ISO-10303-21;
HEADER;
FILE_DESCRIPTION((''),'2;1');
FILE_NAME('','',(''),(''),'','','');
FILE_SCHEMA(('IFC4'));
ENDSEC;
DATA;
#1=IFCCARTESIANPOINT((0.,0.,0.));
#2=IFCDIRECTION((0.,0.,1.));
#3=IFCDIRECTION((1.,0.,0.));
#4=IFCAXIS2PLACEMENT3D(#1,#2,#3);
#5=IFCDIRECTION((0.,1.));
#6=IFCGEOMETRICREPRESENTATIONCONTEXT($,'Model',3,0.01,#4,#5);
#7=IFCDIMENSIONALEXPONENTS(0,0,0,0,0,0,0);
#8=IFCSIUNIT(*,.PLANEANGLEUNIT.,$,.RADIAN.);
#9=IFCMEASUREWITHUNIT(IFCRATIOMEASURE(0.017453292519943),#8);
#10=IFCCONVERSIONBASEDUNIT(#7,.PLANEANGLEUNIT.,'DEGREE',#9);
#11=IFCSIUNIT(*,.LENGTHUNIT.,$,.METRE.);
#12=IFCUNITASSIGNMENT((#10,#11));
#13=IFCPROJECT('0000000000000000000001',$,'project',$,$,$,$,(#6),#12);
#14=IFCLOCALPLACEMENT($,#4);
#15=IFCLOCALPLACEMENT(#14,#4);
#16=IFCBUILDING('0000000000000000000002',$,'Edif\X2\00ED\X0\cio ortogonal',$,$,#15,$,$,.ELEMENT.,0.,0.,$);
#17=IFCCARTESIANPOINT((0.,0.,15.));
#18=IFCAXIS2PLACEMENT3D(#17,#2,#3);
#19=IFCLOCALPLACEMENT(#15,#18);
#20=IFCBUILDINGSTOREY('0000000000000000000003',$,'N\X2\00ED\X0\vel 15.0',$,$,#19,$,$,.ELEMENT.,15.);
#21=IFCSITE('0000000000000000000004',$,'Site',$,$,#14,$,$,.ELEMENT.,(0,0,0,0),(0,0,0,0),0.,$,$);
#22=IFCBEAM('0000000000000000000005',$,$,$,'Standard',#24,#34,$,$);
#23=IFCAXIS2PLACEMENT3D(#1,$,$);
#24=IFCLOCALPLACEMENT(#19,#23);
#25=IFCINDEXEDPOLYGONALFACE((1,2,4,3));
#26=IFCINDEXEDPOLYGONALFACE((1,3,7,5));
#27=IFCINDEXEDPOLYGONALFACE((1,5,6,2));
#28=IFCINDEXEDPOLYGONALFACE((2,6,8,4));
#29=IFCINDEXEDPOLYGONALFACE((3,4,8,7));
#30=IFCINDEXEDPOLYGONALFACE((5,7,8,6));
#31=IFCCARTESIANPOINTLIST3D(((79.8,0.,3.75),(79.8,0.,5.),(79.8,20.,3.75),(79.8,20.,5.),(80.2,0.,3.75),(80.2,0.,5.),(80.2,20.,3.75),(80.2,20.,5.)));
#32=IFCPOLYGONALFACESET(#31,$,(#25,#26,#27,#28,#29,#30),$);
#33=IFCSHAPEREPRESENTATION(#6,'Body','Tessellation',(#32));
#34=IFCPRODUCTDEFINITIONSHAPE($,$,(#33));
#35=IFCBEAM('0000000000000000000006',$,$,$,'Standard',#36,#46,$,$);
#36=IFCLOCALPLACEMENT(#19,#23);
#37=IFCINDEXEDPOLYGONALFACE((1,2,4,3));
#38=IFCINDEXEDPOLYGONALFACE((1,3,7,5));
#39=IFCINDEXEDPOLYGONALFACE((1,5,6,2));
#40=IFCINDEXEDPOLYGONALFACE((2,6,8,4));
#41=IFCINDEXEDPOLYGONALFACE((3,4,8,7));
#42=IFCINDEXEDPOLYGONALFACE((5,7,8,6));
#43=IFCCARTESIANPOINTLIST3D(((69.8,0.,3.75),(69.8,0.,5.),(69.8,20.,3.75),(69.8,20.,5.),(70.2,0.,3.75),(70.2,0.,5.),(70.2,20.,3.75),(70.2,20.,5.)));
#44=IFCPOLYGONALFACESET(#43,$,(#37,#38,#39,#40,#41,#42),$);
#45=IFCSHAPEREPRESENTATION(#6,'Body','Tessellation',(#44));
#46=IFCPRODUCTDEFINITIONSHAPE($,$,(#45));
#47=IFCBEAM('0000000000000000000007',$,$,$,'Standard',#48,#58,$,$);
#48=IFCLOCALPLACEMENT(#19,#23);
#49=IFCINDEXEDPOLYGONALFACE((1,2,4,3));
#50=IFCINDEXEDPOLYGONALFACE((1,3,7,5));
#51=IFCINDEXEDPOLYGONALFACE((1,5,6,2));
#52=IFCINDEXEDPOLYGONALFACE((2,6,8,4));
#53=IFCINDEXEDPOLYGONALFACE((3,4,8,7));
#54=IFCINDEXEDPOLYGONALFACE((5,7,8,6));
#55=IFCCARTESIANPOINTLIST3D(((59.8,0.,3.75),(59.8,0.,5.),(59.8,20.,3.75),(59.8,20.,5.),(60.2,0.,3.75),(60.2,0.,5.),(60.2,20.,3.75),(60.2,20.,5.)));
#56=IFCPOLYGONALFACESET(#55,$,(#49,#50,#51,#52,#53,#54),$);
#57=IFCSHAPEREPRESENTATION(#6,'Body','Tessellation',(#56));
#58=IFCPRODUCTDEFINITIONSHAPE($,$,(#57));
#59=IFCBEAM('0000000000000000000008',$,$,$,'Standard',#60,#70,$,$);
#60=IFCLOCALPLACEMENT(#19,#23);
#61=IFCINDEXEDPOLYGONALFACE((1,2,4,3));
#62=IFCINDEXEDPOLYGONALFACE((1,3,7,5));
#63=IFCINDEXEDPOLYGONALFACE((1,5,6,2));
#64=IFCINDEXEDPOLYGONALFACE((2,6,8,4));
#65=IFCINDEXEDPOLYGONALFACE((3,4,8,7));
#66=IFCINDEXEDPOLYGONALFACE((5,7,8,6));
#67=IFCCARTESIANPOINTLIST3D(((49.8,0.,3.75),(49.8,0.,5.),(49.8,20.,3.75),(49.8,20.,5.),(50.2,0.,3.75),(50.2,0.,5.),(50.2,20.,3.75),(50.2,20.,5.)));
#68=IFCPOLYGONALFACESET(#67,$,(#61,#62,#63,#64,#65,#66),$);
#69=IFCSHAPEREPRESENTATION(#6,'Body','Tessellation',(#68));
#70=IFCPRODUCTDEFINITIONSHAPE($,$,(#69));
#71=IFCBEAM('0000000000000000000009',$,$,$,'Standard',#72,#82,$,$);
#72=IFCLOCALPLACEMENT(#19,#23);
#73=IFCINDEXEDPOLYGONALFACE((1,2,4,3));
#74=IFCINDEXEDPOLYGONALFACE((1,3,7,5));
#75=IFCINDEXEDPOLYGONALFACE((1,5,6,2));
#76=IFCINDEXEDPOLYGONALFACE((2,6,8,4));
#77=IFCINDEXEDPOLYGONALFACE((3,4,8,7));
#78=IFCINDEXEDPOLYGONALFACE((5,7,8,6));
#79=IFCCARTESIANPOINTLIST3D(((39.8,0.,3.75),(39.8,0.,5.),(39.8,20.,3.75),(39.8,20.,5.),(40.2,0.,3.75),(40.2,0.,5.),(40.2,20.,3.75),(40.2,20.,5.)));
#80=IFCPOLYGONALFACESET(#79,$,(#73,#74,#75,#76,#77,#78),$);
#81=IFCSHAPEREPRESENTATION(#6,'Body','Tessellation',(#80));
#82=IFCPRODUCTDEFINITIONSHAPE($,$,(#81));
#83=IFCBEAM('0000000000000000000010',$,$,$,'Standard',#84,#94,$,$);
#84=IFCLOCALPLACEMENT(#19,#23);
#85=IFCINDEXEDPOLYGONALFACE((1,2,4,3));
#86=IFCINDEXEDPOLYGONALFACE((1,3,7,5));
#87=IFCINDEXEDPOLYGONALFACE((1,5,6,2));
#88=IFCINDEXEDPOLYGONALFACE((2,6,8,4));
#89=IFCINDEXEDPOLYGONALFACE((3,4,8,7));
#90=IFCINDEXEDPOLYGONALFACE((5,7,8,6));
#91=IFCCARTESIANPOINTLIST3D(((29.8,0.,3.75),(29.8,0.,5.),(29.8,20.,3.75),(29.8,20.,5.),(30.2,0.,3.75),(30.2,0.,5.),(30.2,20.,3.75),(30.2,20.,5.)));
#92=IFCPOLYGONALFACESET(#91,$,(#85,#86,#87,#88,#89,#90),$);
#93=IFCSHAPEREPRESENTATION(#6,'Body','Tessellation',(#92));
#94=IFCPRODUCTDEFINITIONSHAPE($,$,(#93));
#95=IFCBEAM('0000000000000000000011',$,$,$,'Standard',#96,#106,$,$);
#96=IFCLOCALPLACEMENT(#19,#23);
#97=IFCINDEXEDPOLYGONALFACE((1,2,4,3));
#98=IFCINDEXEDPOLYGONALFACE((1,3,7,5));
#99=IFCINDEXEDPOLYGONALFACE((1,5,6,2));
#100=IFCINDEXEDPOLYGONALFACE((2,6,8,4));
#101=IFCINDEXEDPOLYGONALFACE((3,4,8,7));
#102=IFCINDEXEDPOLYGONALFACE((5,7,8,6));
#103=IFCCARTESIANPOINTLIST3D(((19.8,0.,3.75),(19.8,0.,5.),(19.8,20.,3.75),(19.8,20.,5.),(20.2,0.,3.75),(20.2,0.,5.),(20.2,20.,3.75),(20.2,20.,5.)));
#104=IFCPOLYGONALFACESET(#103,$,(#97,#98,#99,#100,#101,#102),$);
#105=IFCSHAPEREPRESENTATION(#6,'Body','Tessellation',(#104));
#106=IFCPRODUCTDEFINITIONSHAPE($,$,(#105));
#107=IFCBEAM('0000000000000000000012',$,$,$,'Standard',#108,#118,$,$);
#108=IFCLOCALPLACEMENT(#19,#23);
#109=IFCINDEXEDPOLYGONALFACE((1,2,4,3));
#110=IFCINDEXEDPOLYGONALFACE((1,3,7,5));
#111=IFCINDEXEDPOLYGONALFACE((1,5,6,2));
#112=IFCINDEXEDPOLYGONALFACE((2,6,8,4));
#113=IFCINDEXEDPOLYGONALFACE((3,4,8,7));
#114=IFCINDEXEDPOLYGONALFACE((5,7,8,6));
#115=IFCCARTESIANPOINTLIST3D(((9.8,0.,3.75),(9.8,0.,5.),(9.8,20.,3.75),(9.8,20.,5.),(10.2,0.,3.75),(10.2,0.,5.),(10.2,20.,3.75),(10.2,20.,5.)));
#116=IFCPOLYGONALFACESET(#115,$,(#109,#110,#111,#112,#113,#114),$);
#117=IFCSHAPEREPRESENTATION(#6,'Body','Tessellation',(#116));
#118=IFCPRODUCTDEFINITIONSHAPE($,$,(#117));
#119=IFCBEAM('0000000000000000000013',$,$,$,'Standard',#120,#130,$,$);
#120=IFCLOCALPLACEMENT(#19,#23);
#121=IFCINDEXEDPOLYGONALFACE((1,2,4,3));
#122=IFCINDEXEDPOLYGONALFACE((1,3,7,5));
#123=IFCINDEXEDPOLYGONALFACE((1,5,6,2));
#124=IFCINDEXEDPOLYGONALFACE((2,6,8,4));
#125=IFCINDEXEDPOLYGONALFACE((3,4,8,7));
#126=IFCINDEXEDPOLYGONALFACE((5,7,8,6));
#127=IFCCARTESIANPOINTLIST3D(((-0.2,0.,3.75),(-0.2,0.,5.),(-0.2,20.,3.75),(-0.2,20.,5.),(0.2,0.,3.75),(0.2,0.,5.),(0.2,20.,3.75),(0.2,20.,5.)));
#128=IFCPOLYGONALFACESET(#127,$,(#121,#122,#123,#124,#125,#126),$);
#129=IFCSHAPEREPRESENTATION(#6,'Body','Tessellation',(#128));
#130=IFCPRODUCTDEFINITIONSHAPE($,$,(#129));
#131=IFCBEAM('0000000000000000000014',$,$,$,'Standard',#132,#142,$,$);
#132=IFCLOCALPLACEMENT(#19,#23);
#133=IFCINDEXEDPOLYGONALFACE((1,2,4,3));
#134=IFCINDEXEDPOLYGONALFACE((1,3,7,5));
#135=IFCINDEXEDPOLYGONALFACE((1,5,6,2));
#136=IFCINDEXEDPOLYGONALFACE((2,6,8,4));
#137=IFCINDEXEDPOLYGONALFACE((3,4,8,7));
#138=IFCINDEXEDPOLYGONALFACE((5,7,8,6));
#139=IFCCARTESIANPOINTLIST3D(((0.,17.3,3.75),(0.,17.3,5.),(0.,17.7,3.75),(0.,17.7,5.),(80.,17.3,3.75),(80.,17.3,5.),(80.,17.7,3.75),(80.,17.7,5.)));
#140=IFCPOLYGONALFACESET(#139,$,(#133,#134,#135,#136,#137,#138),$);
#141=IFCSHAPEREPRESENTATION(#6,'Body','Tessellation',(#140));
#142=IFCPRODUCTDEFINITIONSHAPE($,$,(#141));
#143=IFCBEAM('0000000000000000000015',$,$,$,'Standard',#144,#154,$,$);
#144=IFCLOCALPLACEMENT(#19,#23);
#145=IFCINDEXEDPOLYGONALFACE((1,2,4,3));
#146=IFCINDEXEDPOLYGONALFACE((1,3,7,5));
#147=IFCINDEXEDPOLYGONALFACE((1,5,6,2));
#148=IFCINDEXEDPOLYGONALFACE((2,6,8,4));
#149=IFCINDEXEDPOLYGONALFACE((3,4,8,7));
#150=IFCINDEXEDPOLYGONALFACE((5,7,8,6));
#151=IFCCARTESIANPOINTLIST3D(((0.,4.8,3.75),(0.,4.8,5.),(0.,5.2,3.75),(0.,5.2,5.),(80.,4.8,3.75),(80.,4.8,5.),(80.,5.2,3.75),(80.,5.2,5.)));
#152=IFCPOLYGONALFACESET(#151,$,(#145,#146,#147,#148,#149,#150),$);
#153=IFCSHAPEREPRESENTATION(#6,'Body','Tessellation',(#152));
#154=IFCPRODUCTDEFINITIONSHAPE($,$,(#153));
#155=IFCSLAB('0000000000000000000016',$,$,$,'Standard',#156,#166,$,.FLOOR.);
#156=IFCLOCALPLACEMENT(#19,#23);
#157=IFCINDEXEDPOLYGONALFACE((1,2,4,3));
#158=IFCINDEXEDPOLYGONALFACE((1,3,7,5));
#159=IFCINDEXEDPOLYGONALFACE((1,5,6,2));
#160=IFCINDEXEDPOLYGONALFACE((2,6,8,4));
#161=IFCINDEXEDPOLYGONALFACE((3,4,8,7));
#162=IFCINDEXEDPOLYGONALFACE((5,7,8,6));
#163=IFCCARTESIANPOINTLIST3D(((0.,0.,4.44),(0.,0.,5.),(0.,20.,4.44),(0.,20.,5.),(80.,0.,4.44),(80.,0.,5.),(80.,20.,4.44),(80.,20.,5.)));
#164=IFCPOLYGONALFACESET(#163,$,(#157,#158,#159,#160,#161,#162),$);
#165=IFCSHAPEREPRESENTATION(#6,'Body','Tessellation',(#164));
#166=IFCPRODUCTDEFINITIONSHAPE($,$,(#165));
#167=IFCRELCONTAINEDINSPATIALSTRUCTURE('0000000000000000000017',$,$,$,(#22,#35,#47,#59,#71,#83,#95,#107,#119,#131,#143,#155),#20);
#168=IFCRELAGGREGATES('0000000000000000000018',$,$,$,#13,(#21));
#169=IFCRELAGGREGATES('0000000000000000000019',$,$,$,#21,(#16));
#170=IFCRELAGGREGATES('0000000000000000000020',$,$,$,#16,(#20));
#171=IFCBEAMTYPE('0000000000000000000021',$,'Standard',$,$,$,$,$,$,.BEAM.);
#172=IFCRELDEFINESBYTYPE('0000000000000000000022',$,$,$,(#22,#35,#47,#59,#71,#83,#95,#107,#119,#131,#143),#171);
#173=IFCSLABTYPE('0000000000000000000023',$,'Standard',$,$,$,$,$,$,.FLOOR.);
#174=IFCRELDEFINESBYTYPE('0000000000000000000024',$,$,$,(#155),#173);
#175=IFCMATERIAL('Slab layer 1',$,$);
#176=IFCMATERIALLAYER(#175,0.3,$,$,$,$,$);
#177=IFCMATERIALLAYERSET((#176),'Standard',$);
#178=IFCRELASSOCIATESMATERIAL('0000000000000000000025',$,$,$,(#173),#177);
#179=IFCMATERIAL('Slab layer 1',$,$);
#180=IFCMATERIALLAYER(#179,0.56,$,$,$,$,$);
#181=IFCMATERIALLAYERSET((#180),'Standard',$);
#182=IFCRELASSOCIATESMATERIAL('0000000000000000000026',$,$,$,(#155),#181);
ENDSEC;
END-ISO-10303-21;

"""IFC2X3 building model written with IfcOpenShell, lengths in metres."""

from ifc_helpers import new_model, entity, si_unit, converted_unit, direction, frame, origin_with_axes, origin_2d, place, context, project, spatial, polyline, rectangle, outline, extrude, material, layer, layer_set, layer_usage, type_object, element, save


model = new_model("IFC2X3")

# Units and contexts
model_context = context("Model", 3, precision=0.01, world=origin_with_axes(), true_north=direction((0.0, 1.0)))
ifc_project = project(units=[converted_unit("PLANEANGLEUNIT", "DEGREE", entity("IfcRatioMeasure", 0.017453292519943), si_unit("PLANEANGLEUNIT", "RADIAN"), dimensions=[0, 0, 0, 0, 0, 0, 0]), si_unit("LENGTHUNIT", "METRE")], contexts=[model_context])

# Site, building, storey
site_placement = place(None, origin_with_axes())
site = spatial("IfcSite", under=ifc_project, at=site_placement, Name="Site", CompositionType="ELEMENT", RefLatitude=(0, 0, 0, 0), RefLongitude=(0, 0, 0, 0), RefElevation=0.0)
building_placement = place(site_placement, origin_with_axes())
building = spatial("IfcBuilding", under=site, at=building_placement, Name="Edifício ortogonal", CompositionType="ELEMENT", ElevationOfRefHeight=0.0, ElevationOfTerrain=0.0)
storey_placement = place(building_placement, frame((0.0, 0.0, 15.0), z_axis=(0.0, 0.0, 1.0), x_axis=(1.0, 0.0, 0.0)))
storey = spatial("IfcBuildingStorey", under=building, at=storey_placement, Name="Nível 15.0", CompositionType="ELEMENT", Elevation=15.0)

# Beams
beam_type = type_object("IfcBeamType", Name="Standard", PredefinedType="BEAM")
for number, where, z_axis, x_axis in (
    (1, (80.0, 20.0, 20.0), (0.0, 0.0, 1.0), (0.0, -1.0, 0.0)),
    (2, (70.0, 20.0, 20.0), (0.0, 0.0, 1.0), (0.0, -1.0, 0.0)),
    (3, (60.0, 20.0, 20.0), (0.0, 0.0, 1.0), (0.0, -1.0, 0.0)),
    (4, (50.0, 20.0, 20.0), (0.0, 0.0, 1.0), (0.0, -1.0, 0.0)),
    (5, (40.0, 20.0, 20.0), (0.0, 0.0, 1.0), (0.0, -1.0, 0.0)),
    (6, (30.0, 20.0, 20.0), (0.0, 0.0, 1.0), (0.0, -1.0, 0.0)),
    (7, (20.0, 20.0, 20.0), (0.0, 0.0, 1.0), (0.0, -1.0, 0.0)),
    (8, (10.0, 20.0, 20.0), (0.0, 0.0, 1.0), (0.0, -1.0, 0.0)),
    (9, (0.0, 20.0, 20.0), (0.0, 0.0, 1.0), (0.0, -1.0, 0.0)),
):
    element("IfcBeam", number, at=place(site_placement, frame(where, z_axis=z_axis, x_axis=x_axis)), inside=storey, type_object=beam_type, ObjectType="Standard", context=model_context, shape_type="SweptSolid", body=[
        extrude(rectangle(XDim=0.4, YDim=1.25, at=origin_2d()), frame((0.0, 0.0, -0.625), z_axis=(1.0, 0.0, 0.0), x_axis=(0.0, 1.0, 0.0)), (0.0, 0.0, 1.0), 20.0),
    ])
for number, where, z_axis, x_axis in (
    (10, (80.0, 17.5, 20.0), (0.0, 0.0, 1.0), (-1.0, 0.0, 0.0)),
    (11, (0.0, 5.0, 20.0), (0.0, 0.0, 1.0), (1.0, 0.0, 0.0)),
):
    element("IfcBeam", number, at=place(site_placement, frame(where, z_axis=z_axis, x_axis=x_axis)), inside=storey, type_object=beam_type, ObjectType="Standard", context=model_context, shape_type="SweptSolid", body=[
        extrude(rectangle(XDim=0.4, YDim=1.25, at=origin_2d()), frame((0.0, 0.0, -0.625), z_axis=(1.0, 0.0, 0.0), x_axis=(0.0, 1.0, 0.0)), (0.0, 0.0, 1.0), 80.0),
    ])

# Slab
ifc_material_1 = material(Name="Slab layer 1")
ifc_layer_1 = layer(ifc_material_1, 0.56)
ifc_layer_set_1 = layer_set([ifc_layer_1], Name="Standard")
ifc_layer_usage = layer_usage(ifc_layer_set_1, "AXIS3", "POSITIVE", 0.0)
ifc_material_2 = material(Name="Slab layer 1")
ifc_layer_2 = layer(ifc_material_2, 0.3)
ifc_layer_set_2 = layer_set([ifc_layer_2], Name="Standard")
slab_type = type_object("IfcSlabType", Name="Standard", PredefinedType="FLOOR", material=ifc_layer_set_2)
slab_placement = place(site_placement, frame((0.0, 0.0, 20.0), z_axis=(0.0, 0.0, 1.0), x_axis=(1.0, 0.0, 0.0)))
element("IfcSlab", 12, at=slab_placement, inside=storey, type_object=slab_type, material=ifc_layer_usage, ObjectType="Standard", PredefinedType="FLOOR", context=model_context, shape_type="SweptSolid", body=[
    extrude(outline(polyline([(0.0, 0.0), (80.0, 0.0), (80.0, 20.0), (0.0, 20.0), (0.0, 0.0)])), frame((0.0, 0.0, -0.56), z_axis=(0.0, 0.0, 1.0), x_axis=(1.0, 0.0, 0.0)), (0.0, 0.0, 1.0), 0.56),
])

save(model, "model.ifc")
